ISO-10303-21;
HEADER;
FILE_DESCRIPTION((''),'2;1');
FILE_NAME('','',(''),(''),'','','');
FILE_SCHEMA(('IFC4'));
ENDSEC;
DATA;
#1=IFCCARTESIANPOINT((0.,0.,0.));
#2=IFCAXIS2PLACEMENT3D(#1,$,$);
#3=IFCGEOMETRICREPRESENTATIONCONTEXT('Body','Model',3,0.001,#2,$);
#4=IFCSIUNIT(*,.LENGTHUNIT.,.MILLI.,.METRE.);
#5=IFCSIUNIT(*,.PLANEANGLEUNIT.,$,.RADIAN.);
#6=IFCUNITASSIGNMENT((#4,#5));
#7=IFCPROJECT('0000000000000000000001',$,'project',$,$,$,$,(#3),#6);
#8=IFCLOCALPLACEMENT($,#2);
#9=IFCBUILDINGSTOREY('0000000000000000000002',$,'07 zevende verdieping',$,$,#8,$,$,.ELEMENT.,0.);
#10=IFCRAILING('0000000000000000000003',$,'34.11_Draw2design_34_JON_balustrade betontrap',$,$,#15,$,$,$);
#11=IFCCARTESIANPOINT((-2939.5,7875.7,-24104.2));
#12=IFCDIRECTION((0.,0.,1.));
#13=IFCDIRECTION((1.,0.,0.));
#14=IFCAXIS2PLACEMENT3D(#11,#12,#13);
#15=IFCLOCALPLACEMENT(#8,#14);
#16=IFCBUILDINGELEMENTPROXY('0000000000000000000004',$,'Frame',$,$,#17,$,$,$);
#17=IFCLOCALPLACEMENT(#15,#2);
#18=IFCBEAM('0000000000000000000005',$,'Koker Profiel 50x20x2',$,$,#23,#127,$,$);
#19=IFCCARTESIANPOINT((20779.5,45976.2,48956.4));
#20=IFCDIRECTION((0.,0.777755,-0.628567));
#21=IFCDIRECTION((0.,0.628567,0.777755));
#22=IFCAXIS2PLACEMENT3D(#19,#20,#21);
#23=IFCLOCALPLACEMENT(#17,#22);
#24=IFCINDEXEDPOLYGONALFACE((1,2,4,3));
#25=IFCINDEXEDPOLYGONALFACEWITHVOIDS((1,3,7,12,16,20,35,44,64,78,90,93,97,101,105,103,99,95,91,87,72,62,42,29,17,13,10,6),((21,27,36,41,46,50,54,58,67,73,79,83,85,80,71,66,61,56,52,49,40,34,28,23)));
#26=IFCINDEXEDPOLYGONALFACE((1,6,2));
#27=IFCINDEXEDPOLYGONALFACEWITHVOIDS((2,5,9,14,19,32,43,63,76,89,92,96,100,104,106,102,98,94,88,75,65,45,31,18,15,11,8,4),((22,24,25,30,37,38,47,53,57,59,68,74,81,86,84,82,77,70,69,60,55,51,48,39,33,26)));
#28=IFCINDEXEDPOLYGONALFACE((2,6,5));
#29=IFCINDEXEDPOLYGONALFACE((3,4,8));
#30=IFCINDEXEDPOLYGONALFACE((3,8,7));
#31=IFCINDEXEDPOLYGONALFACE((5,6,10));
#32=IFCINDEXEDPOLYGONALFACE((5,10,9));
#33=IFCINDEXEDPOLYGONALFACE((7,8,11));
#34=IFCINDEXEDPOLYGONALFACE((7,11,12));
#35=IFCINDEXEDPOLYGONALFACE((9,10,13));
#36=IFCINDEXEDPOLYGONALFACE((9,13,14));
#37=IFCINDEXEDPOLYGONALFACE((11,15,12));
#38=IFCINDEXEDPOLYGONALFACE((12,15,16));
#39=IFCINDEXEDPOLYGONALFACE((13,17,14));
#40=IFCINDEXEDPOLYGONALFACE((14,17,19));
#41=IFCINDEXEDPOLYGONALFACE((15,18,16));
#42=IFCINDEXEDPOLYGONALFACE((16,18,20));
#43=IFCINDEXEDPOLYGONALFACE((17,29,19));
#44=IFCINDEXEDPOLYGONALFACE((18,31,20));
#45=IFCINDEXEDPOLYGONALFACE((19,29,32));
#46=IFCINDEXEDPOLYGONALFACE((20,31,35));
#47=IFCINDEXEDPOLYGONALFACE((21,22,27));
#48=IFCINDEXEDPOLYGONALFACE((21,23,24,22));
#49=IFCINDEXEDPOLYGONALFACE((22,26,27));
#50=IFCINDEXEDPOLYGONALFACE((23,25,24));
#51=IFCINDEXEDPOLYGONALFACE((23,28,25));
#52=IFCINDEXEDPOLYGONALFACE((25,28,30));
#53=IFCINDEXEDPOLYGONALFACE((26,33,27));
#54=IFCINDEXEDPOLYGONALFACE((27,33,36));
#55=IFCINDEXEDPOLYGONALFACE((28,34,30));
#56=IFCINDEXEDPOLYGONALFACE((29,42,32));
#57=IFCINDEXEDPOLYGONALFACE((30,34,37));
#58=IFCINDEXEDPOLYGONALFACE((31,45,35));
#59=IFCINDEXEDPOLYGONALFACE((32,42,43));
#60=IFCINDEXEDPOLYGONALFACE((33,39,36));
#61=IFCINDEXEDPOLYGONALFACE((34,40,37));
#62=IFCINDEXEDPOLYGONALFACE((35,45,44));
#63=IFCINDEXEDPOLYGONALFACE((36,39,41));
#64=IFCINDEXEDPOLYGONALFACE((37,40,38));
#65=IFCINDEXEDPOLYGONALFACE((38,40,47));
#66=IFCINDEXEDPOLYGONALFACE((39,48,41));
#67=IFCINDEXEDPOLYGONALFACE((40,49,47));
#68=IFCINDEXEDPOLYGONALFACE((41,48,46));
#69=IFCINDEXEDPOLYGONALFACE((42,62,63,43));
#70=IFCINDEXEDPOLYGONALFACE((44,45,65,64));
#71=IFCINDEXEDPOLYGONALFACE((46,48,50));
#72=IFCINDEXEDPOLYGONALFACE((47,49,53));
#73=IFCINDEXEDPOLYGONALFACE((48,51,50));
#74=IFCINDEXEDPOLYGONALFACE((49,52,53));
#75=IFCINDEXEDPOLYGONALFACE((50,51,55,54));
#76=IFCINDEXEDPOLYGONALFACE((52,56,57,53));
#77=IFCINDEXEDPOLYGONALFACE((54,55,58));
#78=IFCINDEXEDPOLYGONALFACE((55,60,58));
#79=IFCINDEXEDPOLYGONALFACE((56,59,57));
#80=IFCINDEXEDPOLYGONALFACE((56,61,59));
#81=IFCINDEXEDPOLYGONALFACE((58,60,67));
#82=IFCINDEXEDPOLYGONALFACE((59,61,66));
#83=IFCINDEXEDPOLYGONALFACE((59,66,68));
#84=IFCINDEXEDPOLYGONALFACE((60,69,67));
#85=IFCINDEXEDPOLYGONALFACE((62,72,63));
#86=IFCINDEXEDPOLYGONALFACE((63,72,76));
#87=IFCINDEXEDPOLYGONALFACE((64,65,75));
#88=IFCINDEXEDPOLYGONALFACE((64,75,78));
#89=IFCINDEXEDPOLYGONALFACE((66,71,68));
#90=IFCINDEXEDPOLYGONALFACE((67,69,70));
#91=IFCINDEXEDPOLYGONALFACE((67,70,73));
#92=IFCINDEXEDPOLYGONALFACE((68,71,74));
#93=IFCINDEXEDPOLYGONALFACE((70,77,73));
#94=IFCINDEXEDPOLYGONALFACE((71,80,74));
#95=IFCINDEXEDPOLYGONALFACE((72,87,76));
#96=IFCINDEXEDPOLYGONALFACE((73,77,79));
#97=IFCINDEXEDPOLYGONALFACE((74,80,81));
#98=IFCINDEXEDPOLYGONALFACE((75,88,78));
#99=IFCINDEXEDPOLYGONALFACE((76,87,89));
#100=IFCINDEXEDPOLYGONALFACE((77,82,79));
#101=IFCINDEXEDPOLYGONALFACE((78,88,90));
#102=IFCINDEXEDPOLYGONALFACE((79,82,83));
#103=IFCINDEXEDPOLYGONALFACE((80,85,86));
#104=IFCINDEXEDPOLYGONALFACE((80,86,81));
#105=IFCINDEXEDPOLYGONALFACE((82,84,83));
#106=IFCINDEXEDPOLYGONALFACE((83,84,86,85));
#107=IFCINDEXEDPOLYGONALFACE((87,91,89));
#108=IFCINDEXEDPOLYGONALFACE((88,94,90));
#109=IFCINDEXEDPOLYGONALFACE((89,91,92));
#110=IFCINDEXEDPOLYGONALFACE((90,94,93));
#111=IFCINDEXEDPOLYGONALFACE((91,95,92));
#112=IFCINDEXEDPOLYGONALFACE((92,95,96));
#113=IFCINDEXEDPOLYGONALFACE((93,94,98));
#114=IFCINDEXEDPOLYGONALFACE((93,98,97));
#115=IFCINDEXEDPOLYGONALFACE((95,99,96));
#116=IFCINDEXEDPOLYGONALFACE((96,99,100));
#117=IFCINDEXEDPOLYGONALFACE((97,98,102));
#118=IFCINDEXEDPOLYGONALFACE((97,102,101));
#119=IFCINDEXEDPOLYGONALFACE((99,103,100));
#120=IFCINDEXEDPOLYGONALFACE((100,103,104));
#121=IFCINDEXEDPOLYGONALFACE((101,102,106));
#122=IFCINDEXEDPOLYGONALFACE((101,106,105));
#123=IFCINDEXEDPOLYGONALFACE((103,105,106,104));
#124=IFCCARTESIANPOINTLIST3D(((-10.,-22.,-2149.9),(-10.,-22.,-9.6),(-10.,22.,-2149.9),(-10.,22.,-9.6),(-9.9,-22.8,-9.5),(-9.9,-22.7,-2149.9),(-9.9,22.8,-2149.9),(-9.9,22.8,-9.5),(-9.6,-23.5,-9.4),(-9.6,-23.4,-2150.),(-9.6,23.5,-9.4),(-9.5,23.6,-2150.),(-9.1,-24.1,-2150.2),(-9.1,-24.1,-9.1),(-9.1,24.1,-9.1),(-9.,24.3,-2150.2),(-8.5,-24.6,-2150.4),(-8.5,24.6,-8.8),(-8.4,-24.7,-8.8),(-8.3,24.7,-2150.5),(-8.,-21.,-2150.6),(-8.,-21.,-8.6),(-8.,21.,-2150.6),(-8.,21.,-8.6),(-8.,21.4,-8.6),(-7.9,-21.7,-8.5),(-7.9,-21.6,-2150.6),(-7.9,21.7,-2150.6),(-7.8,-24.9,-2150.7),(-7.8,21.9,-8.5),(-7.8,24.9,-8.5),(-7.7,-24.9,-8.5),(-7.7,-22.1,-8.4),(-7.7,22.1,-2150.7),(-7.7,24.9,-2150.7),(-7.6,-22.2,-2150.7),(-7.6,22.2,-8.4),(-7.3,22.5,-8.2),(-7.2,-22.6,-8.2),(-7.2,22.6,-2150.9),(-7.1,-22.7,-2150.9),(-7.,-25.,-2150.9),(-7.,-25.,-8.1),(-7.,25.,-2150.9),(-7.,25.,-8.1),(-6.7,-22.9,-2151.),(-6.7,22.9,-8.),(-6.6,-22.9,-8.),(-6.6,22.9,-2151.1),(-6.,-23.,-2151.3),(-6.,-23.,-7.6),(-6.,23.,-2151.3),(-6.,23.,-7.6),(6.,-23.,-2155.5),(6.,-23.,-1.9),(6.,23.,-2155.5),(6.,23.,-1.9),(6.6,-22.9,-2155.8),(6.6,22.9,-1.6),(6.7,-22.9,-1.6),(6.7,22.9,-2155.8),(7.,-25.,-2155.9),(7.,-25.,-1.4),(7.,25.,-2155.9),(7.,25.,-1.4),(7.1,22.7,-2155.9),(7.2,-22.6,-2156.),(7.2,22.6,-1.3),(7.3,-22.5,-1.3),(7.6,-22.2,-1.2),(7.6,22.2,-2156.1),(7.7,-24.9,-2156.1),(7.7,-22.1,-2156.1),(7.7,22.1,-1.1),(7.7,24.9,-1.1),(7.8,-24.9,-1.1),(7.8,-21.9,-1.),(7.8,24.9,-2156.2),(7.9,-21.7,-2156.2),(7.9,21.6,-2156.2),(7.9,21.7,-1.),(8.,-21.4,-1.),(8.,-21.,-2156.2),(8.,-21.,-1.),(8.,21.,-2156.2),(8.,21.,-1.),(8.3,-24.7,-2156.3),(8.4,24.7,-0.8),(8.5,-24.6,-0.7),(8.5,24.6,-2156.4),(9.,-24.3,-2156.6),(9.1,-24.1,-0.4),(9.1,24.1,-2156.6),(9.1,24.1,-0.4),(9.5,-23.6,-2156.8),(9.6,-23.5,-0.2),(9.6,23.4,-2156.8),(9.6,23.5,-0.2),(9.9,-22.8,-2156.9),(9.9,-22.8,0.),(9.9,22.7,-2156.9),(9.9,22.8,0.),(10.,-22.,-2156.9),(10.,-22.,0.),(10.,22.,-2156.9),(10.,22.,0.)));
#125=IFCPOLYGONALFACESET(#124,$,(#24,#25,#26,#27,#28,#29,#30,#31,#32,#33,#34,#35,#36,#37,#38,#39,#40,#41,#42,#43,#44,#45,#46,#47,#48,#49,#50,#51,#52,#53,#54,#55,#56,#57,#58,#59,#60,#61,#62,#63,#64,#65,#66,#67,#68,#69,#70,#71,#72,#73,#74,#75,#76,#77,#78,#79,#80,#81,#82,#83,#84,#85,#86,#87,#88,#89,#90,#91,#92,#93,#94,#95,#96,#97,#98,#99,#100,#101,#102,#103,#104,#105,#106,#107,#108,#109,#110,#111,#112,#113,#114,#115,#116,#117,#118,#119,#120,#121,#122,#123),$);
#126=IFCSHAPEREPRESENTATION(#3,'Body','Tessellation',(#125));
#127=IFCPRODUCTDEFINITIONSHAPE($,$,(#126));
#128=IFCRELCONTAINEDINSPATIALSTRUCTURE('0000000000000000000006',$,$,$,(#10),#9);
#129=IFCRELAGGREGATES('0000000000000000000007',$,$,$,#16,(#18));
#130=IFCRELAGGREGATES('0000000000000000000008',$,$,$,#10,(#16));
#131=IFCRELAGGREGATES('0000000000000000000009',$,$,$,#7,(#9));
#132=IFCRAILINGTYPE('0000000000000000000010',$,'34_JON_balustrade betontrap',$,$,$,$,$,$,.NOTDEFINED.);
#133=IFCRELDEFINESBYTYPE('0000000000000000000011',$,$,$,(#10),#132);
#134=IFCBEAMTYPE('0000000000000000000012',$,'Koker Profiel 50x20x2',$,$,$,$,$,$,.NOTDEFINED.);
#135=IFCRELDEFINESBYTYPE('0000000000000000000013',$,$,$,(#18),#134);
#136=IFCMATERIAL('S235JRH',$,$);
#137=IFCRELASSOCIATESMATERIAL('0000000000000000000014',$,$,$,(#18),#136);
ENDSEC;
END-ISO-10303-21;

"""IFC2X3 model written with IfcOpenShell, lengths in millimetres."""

from ifc_helpers import new_model, si_unit, frame, origin, origin_2d, place, context, project, spatial, hollow_rectangle, extrude, clip, halfspace, source, transform, mapped, material, type_object, element, aggregate, save


model = new_model("IFC2X3")

# Units and contexts
model_context = context("Model", 3, precision=0.001, world=origin(), identifier="Body")
ifc_project = project(units=[si_unit("LENGTHUNIT", "METRE", prefix="MILLI"), si_unit("PLANEANGLEUNIT", "RADIAN")], contexts=[model_context])

# Storey
storey_placement = place(None, origin())
storey = spatial("IfcBuildingStorey", under=ifc_project, at=storey_placement, Name="07 zevende verdieping", CompositionType="ELEMENT", Elevation=0.0)

# Railing, building element proxy, beam
railing_type = type_object("IfcRailingType", Name="34_JON_balustrade betontrap")
railing_placement = place(storey_placement, frame((-2939.5, 7875.7, -24104.2), z_axis=(0.0, 0.0, 1.0), x_axis=(1.0, 0.0, 0.0)))
railing = element("IfcRailing", 1, at=railing_placement, inside=storey, type_object=railing_type, Name="34.11_Draw2design_34_JON_balustrade betontrap")
ifc_material_1 = material(Name="S235JRH")
proxy_1_placement = place(railing_placement, origin())
proxy_1 = element("IfcBuildingElementProxy", 2, at=proxy_1_placement, Name="Frame")
beam_type_1 = type_object("IfcBeamType", Name="Koker Profiel 50x20x2")
shared_shape_1 = source(origin(), model_context, "Body", "Clipping", [
    clip(clip(extrude(hollow_rectangle(XDim=20.0, YDim=50.0, WallThickness=2.0, InnerFilletRadius=2.0, OuterFilletRadius=3.0, at=origin_2d()), origin(), (0.0, 0.0, -1.0), 2156.9), halfspace(frame((-10.0, 25.0, -9.6), z_axis=(-0.430948, 0.0, 0.902377), x_axis=(-0.902377, 0.0, -0.430948)), False)), halfspace(frame((-10.0, -25.0, -2149.9), z_axis=(-0.33335, 0.0, -0.942803), x_axis=(0.0, -1.0, 0.0)), False)),
])
beam_1_placement = place(proxy_1_placement, frame((20779.5, 45976.2, 48956.4), z_axis=(0.0, 0.777755, -0.628567), x_axis=(0.0, 0.628567, 0.777755)))
beam_1 = element("IfcBeam", 3, at=beam_1_placement, type_object=beam_type_1, material=ifc_material_1, Name="Koker Profiel 50x20x2", context=model_context, shape_type="MappedRepresentation", body=[
    mapped(shared_shape_1, transform((0.0, 0.0, 0.0), scale=1.0)),
])
aggregate(proxy_1, [beam_1])
aggregate(railing, [proxy_1])

save(model, "model.ifc")
